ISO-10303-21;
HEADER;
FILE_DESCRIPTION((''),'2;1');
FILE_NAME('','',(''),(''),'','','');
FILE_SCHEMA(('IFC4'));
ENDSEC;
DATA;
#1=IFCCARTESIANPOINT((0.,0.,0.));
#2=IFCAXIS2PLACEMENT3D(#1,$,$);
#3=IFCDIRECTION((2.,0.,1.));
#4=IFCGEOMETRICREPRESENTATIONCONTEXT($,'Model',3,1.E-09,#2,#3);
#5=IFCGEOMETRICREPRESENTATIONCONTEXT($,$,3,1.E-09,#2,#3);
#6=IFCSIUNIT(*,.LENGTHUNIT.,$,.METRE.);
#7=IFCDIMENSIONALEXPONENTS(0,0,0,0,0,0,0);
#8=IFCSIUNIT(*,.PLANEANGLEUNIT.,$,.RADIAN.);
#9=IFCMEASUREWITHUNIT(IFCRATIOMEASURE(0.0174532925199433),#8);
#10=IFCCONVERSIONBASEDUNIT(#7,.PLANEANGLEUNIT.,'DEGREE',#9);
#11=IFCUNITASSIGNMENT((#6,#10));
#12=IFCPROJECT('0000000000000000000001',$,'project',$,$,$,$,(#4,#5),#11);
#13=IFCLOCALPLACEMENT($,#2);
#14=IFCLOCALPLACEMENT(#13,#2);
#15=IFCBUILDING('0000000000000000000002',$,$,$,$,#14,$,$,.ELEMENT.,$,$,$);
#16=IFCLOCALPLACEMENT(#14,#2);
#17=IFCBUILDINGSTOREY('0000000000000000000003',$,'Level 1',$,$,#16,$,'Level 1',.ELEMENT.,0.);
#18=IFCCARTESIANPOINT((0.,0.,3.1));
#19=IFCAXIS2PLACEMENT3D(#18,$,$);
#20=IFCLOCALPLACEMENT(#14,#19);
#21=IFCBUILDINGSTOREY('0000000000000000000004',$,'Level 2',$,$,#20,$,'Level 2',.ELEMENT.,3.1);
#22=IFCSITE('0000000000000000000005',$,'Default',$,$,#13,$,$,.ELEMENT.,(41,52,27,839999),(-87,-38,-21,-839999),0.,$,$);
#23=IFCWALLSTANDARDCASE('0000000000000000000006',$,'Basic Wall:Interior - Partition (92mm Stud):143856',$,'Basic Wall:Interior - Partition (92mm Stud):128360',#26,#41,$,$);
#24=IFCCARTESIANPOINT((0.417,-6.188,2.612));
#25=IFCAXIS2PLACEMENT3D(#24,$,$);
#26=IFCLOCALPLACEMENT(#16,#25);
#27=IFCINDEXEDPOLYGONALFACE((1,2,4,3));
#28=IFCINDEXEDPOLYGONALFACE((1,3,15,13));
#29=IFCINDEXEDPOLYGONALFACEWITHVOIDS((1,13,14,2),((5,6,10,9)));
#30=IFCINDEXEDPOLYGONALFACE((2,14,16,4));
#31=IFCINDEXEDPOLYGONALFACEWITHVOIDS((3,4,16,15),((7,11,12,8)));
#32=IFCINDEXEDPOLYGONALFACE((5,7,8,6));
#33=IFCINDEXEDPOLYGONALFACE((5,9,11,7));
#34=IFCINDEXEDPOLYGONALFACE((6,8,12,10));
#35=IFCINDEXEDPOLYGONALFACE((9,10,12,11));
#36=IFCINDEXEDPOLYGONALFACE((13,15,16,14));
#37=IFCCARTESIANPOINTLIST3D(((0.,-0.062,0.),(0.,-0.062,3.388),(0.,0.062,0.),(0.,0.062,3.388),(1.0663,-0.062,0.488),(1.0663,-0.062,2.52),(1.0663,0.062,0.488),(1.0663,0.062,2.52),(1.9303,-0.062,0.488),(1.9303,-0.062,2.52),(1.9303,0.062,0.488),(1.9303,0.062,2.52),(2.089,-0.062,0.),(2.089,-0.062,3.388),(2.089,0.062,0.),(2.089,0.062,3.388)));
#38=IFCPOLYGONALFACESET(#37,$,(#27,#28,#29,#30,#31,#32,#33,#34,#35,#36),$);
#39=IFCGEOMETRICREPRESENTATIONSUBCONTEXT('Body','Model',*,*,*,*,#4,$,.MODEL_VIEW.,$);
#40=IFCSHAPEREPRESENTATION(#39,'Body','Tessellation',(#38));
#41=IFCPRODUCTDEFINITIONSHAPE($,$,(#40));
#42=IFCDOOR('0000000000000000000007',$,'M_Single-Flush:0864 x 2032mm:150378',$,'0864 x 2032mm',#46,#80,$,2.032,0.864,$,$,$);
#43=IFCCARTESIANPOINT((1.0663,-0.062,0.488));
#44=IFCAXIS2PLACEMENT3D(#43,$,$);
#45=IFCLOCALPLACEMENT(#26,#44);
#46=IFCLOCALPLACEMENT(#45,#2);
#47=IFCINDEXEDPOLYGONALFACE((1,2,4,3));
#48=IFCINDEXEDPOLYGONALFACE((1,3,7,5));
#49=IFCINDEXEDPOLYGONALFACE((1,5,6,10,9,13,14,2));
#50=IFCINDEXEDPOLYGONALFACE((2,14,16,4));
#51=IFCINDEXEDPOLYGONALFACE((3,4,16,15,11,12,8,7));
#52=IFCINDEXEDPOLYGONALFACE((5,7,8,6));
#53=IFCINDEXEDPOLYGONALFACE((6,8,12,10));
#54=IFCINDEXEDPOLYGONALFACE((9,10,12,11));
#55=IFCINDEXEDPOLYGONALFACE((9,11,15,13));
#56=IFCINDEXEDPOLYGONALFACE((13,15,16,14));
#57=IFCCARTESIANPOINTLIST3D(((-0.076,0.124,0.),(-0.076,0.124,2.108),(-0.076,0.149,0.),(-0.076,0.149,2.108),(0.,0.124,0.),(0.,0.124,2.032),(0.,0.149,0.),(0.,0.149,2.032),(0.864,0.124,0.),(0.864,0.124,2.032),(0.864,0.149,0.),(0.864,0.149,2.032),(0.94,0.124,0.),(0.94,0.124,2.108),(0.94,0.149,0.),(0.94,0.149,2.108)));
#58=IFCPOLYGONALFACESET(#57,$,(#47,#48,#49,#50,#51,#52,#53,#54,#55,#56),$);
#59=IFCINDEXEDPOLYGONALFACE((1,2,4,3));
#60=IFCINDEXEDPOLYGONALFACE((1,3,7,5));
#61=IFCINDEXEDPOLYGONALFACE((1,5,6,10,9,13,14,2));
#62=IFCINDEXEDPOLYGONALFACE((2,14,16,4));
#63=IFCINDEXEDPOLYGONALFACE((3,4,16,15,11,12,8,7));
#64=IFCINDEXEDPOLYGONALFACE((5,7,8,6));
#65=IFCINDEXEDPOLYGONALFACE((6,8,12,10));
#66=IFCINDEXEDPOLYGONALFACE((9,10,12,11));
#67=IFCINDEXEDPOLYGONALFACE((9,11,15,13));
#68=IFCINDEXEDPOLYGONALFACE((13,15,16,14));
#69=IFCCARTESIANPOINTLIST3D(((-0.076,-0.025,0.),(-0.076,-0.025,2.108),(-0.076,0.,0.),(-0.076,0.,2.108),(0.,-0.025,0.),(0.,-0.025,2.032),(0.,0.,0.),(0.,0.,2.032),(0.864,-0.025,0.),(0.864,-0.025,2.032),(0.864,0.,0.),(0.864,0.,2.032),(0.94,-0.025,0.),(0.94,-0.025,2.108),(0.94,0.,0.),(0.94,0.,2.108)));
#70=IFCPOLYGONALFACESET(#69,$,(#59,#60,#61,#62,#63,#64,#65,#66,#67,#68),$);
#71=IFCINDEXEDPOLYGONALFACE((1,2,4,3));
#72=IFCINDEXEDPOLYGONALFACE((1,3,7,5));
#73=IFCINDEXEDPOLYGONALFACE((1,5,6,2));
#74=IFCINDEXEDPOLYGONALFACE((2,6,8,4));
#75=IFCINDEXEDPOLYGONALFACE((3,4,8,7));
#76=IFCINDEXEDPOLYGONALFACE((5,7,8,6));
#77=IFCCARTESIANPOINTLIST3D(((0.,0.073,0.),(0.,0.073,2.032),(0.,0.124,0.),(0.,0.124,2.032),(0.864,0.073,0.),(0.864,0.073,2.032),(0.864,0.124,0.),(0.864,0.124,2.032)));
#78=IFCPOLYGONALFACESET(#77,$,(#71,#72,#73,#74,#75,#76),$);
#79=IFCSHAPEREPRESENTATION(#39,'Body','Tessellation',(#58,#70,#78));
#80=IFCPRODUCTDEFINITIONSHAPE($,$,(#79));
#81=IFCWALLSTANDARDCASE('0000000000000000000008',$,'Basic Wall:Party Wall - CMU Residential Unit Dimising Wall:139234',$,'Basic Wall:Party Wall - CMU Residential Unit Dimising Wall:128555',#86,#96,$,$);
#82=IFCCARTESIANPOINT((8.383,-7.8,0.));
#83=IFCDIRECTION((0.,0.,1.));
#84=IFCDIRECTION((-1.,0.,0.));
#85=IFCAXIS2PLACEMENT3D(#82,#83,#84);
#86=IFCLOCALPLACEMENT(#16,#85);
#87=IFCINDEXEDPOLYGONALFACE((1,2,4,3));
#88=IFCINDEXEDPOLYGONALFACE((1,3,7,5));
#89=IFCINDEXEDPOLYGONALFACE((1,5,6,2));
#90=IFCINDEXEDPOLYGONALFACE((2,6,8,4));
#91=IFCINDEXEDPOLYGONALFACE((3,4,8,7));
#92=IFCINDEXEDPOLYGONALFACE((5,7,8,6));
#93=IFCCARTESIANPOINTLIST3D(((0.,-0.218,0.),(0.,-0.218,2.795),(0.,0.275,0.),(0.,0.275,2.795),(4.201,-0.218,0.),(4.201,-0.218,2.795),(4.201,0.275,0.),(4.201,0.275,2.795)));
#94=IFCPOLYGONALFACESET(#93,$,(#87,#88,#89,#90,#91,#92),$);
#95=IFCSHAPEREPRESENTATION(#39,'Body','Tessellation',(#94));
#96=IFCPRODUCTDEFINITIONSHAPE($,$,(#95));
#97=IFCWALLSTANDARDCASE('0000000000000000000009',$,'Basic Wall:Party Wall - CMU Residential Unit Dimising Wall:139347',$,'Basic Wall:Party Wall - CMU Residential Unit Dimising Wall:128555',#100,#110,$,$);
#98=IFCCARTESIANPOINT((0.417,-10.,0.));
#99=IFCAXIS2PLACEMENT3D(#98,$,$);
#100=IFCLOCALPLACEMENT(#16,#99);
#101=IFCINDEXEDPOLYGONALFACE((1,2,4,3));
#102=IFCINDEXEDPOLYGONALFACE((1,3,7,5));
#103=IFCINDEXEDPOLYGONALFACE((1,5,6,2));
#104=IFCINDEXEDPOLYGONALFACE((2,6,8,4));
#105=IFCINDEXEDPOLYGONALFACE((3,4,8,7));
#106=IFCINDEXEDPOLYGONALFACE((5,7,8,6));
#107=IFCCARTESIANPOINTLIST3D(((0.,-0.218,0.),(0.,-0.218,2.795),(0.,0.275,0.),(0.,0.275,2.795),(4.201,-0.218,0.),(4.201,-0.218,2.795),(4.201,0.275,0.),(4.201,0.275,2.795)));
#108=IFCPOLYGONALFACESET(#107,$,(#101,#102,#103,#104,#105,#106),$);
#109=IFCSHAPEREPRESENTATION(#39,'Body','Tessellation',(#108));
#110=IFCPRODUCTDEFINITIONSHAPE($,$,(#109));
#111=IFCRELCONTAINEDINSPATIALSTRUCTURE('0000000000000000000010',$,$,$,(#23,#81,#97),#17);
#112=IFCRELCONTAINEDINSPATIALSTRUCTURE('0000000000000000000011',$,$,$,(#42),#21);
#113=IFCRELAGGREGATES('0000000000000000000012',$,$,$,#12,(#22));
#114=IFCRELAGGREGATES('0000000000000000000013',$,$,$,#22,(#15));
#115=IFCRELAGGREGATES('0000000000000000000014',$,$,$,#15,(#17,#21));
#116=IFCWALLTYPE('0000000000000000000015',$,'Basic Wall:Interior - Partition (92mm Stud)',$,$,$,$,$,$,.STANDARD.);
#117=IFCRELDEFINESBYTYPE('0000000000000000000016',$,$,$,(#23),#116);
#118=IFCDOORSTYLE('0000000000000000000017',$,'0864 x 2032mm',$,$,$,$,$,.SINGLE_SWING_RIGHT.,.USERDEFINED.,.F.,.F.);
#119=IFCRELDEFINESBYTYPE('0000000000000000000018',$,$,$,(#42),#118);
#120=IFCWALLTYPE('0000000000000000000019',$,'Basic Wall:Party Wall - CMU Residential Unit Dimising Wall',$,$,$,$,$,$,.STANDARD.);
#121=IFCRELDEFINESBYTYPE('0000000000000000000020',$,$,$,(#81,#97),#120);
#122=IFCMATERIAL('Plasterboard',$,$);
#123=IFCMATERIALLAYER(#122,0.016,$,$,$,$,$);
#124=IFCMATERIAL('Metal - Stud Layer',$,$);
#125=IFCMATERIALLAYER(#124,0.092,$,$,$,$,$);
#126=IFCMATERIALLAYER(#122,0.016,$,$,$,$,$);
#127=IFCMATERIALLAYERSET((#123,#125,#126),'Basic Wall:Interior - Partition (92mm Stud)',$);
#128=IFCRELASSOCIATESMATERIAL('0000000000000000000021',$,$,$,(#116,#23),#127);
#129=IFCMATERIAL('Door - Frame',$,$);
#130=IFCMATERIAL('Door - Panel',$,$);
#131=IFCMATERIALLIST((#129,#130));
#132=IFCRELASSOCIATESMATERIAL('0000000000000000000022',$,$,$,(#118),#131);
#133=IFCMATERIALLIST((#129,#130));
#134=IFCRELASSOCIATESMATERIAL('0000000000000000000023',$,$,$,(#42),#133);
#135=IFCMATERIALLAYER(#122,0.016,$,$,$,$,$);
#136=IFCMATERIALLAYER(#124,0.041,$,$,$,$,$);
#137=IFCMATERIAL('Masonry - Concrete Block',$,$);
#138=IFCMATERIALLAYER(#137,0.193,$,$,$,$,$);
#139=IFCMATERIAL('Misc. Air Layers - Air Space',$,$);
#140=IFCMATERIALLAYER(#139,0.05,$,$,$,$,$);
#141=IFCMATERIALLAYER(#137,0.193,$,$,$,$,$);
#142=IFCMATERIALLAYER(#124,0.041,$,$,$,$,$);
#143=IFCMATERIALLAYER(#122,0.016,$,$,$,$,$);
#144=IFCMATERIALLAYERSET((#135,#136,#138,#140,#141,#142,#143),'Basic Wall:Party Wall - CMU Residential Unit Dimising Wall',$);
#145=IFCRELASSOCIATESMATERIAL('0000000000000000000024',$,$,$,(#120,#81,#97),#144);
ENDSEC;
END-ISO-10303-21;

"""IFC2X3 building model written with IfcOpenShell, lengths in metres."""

from ifc_helpers import new_model, entity, si_unit, converted_unit, direction, frame, frame_2d, origin, origin_2d_with_axis, place, context, subcontext, project, spatial, polyline, rectangle, outline, extrude, clip, bounded_halfspace, source, transform, mapped, material, material_list, layer, layer_set, layer_usage, type_object, type_shapes, element, fill, save


model = new_model("IFC2X3")

# Units and contexts
model_context = context("Model", 3, precision=1e-09, world=origin(), true_north=direction((2.0, 0.0, 1.0)))
context_of_model = context(None, 3, precision=1e-09, world=origin(), true_north=direction((2.0, 0.0, 1.0)))
body_context = subcontext(model_context, "Body", "Model", "MODEL_VIEW")
ifc_project = project(units=[si_unit("LENGTHUNIT", "METRE"), converted_unit("PLANEANGLEUNIT", "DEGREE", entity("IfcRatioMeasure", 0.0174532925199433), si_unit("PLANEANGLEUNIT", "RADIAN"), dimensions=[0, 0, 0, 0, 0, 0, 0])], contexts=[model_context, context_of_model])

# Site, building, storey
site_placement = place(None, origin())
site = spatial("IfcSite", under=ifc_project, at=site_placement, Name="Default", CompositionType="ELEMENT", RefLatitude=(41, 52, 27, 839999), RefLongitude=(-87, -38, -21, -839999), RefElevation=0.0)
building_placement = place(site_placement, origin())
building = spatial("IfcBuilding", under=site, at=building_placement, CompositionType="ELEMENT")
storey_1_placement = place(building_placement, origin())
storey_1 = spatial("IfcBuildingStorey", under=building, at=storey_1_placement, Name="Level 1", LongName="Level 1", CompositionType="ELEMENT", Elevation=0.0)

# Shared definitions
ifc_material_1 = material(Name="Plasterboard")
ifc_layer_1 = layer(ifc_material_1, 0.016)
ifc_material_2 = material(Name="Metal - Stud Layer")
ifc_layer_2 = layer(ifc_material_2, 0.092)
ifc_layer_3 = layer(ifc_material_1, 0.016)
ifc_layer_set_1 = layer_set([ifc_layer_1, ifc_layer_2, ifc_layer_3], Name="Basic Wall:Interior - Partition (92mm Stud)")
wall_type_1 = type_object("IfcWallType", Name="Basic Wall:Interior - Partition (92mm Stud)", PredefinedType="STANDARD", material=ifc_layer_set_1)
ifc_material_3 = material(Name="Door - Frame")
ifc_material_4 = material(Name="Door - Panel")

# Wall, opening
ifc_layer_usage_1 = layer_usage(ifc_layer_set_1, "AXIS2", "NEGATIVE", 0.062)
wall_1_placement = place(storey_1_placement, frame((0.417, -6.188, 2.612)))
wall_1 = element("IfcWallStandardCase", 1, at=wall_1_placement, inside=storey_1, type_object=wall_type_1, material=ifc_layer_usage_1, Name="Basic Wall:Interior - Partition (92mm Stud):143856", ObjectType="Basic Wall:Interior - Partition (92mm Stud):128360", context=body_context, shape_type="SweptSolid", body=[
    extrude(rectangle(XDim=2.089, YDim=0.124, at=frame_2d((1.0445, 0.0), x_axis=(-1.0, 0.0))), origin(), (0.0, 0.0, 1.0), 3.388),
])
opening_1_placement = place(wall_1_placement, frame((1.0663, -0.062, 0.488)))
opening_1 = element("IfcOpeningElement", 2, at=opening_1_placement, cuts=wall_1, ObjectType="Opening", context=body_context, shape_type="SweptSolid", body=[
    extrude(rectangle(XDim=0.864, YDim=2.032, at=frame_2d((1.016, 0.432), x_axis=(0.0, 1.0))), frame((0.0, 0.0, 0.0), z_axis=(0.0, 1.0, 0.0), x_axis=(0.0, 0.0, 1.0)), (0.0, 0.0, 1.0), 0.124),
])

# Shared definitions
storey_2_placement = place(building_placement, frame((0.0, 0.0, 3.1)))
storey_2 = spatial("IfcBuildingStorey", under=building, at=storey_2_placement, Name="Level 2", LongName="Level 2", CompositionType="ELEMENT", Elevation=3.1)

# Door
ifc_material_list_1 = material_list([ifc_material_3, ifc_material_4])
ifc_material_list_2 = material_list([ifc_material_3, ifc_material_4])
door_style_1 = type_object("IfcDoorStyle", Name="0864 x 2032mm", ConstructionType="USERDEFINED", OperationType="SINGLE_SWING_RIGHT", ParameterTakesPrecedence=False, Sizeable=False, material=ifc_material_list_2)
shared_shape_1 = source(origin(), body_context, "Body", "SweptSolid", [
    extrude(outline(polyline([(-0.508, -1.073), (0.508, -1.073), (0.508, 1.035), (0.432, 1.035), (0.432, -0.997), (-0.432, -0.997), (-0.432, 1.035), (-0.508, 1.035), (-0.508, -1.073)])), frame((0.432, 0.124, 1.035), z_axis=(0.0, 1.0, 0.0), x_axis=(1.0, 0.0, 0.0)), (0.0, 0.0, 1.0), 0.025),
    extrude(outline(polyline([(-1.073, -0.508), (1.035, -0.508), (1.035, -0.432), (-0.997, -0.432), (-0.997, 0.432), (1.035, 0.432), (1.035, 0.508), (-1.073, 0.508), (-1.073, -0.508)])), frame((0.432, -0.025, 1.035), z_axis=(0.0, 1.0, 0.0), x_axis=(0.0, 0.0, -1.0)), (0.0, 0.0, 1.0), 0.025),
    extrude(rectangle(XDim=0.051, YDim=0.864, at=origin_2d_with_axis()), frame((0.432, 0.0985, 0.0), z_axis=(0.0, 0.0, 1.0), x_axis=(0.0, 1.0, 0.0)), (0.0, 0.0, 1.0), 2.032),
])
type_shapes(door_style_1, [shared_shape_1])
door_1_placement = place(opening_1_placement, origin())
door_1 = element("IfcDoor", 3, at=door_1_placement, inside=storey_2, type_object=door_style_1, material=ifc_material_list_1, Name="M_Single-Flush:0864 x 2032mm:150378", ObjectType="0864 x 2032mm", OverallHeight=2.032, OverallWidth=0.864, context=body_context, shape_type="MappedRepresentation", body=[
    mapped(shared_shape_1, transform((0.0, 0.0, 0.0), scale=1.0)),
])
fill(opening_1, door_1)

# Walls
ifc_layer_4 = layer(ifc_material_1, 0.016)
ifc_layer_5 = layer(ifc_material_2, 0.041)
ifc_material_5 = material(Name="Masonry - Concrete Block")
ifc_layer_6 = layer(ifc_material_5, 0.193)
ifc_material_6 = material(Name="Misc. Air Layers - Air Space")
ifc_layer_7 = layer(ifc_material_6, 0.05)
ifc_layer_8 = layer(ifc_material_5, 0.193)
ifc_layer_9 = layer(ifc_material_2, 0.041)
ifc_layer_10 = layer(ifc_material_1, 0.016)
ifc_layer_set_2 = layer_set([ifc_layer_4, ifc_layer_5, ifc_layer_6, ifc_layer_7, ifc_layer_8, ifc_layer_9, ifc_layer_10], Name="Basic Wall:Party Wall - CMU Residential Unit Dimising Wall")
ifc_layer_usage_2 = layer_usage(ifc_layer_set_2, "AXIS2", "NEGATIVE", 0.275)
wall_type_2 = type_object("IfcWallType", Name="Basic Wall:Party Wall - CMU Residential Unit Dimising Wall", PredefinedType="STANDARD", material=ifc_layer_set_2)
wall_2_placement = place(storey_1_placement, frame((8.383, -7.8, 0.0), z_axis=(0.0, 0.0, 1.0), x_axis=(-1.0, 0.0, 0.0)))
element("IfcWallStandardCase", 4, at=wall_2_placement, inside=storey_1, type_object=wall_type_2, material=ifc_layer_usage_2, Name="Basic Wall:Party Wall - CMU Residential Unit Dimising Wall:139234", ObjectType="Basic Wall:Party Wall - CMU Residential Unit Dimising Wall:128555", context=body_context, shape_type="Clipping", body=[
    clip(clip(extrude(rectangle(XDim=4.201, YDim=0.55, at=frame_2d((2.1005, 0.0), x_axis=(-1.0, 0.0))), origin(), (0.0, 0.0, 1.0), 2.795), bounded_halfspace(frame((0.0, -0.218, 2.795), z_axis=(0.0, 1.0, 0.0), x_axis=(-1.0, 0.0, 0.0)), True, frame((0.0, -0.218, 2.795), z_axis=(0.0, 1.0, 0.0), x_axis=(-1.0, 0.0, 0.0)), polyline([(0.0, 0.0), (-3.708, 0.0), (-4.201, 0.0), (-4.201, -2.795), (0.0, -2.795), (0.0, 0.0)]))), bounded_halfspace(frame((4.201, 0.275, 0.0), z_axis=(-1.0, 0.0, 0.0), x_axis=(0.0, -1.0, 0.0)), True, frame((4.201, 0.275, 0.0), z_axis=(-1.0, 0.0, 0.0), x_axis=(0.0, -1.0, 0.0)), polyline([(0.0, 0.0), (0.493, 0.0), (0.493, 2.795), (0.0, 2.795), (0.0, 0.0)]))),
])
ifc_layer_usage_3 = layer_usage(ifc_layer_set_2, "AXIS2", "NEGATIVE", 0.275)
wall_3_placement = place(storey_1_placement, frame((0.417, -10.0, 0.0)))
element("IfcWallStandardCase", 5, at=wall_3_placement, inside=storey_1, type_object=wall_type_2, material=ifc_layer_usage_3, Name="Basic Wall:Party Wall - CMU Residential Unit Dimising Wall:139347", ObjectType="Basic Wall:Party Wall - CMU Residential Unit Dimising Wall:128555", context=body_context, shape_type="Clipping", body=[
    clip(clip(extrude(rectangle(XDim=4.201, YDim=0.55, at=frame_2d((2.1005, 0.0), x_axis=(-1.0, 0.0))), origin(), (0.0, 0.0, 1.0), 2.795), bounded_halfspace(frame((0.0, -0.218, 0.0), z_axis=(0.0, 1.0, 0.0), x_axis=(-1.0, 0.0, 0.0)), True, frame((0.0, -0.218, 0.0), z_axis=(0.0, 1.0, 0.0), x_axis=(-1.0, 0.0, 0.0)), polyline([(0.0, 0.0), (0.0, 2.795), (-4.201, 2.795), (-4.201, 0.0), (0.0, 0.0)]))), bounded_halfspace(frame((4.201, 0.275, 0.0), z_axis=(-1.0, 0.0, 0.0), x_axis=(0.0, -1.0, 0.0)), True, frame((4.201, 0.275, 0.0), z_axis=(-1.0, 0.0, 0.0), x_axis=(0.0, -1.0, 0.0)), polyline([(0.0, 0.0), (0.493, 0.0), (0.493, 2.795), (0.0, 2.795), (0.0, 0.0)]))),
])

save(model, "model.ifc")
